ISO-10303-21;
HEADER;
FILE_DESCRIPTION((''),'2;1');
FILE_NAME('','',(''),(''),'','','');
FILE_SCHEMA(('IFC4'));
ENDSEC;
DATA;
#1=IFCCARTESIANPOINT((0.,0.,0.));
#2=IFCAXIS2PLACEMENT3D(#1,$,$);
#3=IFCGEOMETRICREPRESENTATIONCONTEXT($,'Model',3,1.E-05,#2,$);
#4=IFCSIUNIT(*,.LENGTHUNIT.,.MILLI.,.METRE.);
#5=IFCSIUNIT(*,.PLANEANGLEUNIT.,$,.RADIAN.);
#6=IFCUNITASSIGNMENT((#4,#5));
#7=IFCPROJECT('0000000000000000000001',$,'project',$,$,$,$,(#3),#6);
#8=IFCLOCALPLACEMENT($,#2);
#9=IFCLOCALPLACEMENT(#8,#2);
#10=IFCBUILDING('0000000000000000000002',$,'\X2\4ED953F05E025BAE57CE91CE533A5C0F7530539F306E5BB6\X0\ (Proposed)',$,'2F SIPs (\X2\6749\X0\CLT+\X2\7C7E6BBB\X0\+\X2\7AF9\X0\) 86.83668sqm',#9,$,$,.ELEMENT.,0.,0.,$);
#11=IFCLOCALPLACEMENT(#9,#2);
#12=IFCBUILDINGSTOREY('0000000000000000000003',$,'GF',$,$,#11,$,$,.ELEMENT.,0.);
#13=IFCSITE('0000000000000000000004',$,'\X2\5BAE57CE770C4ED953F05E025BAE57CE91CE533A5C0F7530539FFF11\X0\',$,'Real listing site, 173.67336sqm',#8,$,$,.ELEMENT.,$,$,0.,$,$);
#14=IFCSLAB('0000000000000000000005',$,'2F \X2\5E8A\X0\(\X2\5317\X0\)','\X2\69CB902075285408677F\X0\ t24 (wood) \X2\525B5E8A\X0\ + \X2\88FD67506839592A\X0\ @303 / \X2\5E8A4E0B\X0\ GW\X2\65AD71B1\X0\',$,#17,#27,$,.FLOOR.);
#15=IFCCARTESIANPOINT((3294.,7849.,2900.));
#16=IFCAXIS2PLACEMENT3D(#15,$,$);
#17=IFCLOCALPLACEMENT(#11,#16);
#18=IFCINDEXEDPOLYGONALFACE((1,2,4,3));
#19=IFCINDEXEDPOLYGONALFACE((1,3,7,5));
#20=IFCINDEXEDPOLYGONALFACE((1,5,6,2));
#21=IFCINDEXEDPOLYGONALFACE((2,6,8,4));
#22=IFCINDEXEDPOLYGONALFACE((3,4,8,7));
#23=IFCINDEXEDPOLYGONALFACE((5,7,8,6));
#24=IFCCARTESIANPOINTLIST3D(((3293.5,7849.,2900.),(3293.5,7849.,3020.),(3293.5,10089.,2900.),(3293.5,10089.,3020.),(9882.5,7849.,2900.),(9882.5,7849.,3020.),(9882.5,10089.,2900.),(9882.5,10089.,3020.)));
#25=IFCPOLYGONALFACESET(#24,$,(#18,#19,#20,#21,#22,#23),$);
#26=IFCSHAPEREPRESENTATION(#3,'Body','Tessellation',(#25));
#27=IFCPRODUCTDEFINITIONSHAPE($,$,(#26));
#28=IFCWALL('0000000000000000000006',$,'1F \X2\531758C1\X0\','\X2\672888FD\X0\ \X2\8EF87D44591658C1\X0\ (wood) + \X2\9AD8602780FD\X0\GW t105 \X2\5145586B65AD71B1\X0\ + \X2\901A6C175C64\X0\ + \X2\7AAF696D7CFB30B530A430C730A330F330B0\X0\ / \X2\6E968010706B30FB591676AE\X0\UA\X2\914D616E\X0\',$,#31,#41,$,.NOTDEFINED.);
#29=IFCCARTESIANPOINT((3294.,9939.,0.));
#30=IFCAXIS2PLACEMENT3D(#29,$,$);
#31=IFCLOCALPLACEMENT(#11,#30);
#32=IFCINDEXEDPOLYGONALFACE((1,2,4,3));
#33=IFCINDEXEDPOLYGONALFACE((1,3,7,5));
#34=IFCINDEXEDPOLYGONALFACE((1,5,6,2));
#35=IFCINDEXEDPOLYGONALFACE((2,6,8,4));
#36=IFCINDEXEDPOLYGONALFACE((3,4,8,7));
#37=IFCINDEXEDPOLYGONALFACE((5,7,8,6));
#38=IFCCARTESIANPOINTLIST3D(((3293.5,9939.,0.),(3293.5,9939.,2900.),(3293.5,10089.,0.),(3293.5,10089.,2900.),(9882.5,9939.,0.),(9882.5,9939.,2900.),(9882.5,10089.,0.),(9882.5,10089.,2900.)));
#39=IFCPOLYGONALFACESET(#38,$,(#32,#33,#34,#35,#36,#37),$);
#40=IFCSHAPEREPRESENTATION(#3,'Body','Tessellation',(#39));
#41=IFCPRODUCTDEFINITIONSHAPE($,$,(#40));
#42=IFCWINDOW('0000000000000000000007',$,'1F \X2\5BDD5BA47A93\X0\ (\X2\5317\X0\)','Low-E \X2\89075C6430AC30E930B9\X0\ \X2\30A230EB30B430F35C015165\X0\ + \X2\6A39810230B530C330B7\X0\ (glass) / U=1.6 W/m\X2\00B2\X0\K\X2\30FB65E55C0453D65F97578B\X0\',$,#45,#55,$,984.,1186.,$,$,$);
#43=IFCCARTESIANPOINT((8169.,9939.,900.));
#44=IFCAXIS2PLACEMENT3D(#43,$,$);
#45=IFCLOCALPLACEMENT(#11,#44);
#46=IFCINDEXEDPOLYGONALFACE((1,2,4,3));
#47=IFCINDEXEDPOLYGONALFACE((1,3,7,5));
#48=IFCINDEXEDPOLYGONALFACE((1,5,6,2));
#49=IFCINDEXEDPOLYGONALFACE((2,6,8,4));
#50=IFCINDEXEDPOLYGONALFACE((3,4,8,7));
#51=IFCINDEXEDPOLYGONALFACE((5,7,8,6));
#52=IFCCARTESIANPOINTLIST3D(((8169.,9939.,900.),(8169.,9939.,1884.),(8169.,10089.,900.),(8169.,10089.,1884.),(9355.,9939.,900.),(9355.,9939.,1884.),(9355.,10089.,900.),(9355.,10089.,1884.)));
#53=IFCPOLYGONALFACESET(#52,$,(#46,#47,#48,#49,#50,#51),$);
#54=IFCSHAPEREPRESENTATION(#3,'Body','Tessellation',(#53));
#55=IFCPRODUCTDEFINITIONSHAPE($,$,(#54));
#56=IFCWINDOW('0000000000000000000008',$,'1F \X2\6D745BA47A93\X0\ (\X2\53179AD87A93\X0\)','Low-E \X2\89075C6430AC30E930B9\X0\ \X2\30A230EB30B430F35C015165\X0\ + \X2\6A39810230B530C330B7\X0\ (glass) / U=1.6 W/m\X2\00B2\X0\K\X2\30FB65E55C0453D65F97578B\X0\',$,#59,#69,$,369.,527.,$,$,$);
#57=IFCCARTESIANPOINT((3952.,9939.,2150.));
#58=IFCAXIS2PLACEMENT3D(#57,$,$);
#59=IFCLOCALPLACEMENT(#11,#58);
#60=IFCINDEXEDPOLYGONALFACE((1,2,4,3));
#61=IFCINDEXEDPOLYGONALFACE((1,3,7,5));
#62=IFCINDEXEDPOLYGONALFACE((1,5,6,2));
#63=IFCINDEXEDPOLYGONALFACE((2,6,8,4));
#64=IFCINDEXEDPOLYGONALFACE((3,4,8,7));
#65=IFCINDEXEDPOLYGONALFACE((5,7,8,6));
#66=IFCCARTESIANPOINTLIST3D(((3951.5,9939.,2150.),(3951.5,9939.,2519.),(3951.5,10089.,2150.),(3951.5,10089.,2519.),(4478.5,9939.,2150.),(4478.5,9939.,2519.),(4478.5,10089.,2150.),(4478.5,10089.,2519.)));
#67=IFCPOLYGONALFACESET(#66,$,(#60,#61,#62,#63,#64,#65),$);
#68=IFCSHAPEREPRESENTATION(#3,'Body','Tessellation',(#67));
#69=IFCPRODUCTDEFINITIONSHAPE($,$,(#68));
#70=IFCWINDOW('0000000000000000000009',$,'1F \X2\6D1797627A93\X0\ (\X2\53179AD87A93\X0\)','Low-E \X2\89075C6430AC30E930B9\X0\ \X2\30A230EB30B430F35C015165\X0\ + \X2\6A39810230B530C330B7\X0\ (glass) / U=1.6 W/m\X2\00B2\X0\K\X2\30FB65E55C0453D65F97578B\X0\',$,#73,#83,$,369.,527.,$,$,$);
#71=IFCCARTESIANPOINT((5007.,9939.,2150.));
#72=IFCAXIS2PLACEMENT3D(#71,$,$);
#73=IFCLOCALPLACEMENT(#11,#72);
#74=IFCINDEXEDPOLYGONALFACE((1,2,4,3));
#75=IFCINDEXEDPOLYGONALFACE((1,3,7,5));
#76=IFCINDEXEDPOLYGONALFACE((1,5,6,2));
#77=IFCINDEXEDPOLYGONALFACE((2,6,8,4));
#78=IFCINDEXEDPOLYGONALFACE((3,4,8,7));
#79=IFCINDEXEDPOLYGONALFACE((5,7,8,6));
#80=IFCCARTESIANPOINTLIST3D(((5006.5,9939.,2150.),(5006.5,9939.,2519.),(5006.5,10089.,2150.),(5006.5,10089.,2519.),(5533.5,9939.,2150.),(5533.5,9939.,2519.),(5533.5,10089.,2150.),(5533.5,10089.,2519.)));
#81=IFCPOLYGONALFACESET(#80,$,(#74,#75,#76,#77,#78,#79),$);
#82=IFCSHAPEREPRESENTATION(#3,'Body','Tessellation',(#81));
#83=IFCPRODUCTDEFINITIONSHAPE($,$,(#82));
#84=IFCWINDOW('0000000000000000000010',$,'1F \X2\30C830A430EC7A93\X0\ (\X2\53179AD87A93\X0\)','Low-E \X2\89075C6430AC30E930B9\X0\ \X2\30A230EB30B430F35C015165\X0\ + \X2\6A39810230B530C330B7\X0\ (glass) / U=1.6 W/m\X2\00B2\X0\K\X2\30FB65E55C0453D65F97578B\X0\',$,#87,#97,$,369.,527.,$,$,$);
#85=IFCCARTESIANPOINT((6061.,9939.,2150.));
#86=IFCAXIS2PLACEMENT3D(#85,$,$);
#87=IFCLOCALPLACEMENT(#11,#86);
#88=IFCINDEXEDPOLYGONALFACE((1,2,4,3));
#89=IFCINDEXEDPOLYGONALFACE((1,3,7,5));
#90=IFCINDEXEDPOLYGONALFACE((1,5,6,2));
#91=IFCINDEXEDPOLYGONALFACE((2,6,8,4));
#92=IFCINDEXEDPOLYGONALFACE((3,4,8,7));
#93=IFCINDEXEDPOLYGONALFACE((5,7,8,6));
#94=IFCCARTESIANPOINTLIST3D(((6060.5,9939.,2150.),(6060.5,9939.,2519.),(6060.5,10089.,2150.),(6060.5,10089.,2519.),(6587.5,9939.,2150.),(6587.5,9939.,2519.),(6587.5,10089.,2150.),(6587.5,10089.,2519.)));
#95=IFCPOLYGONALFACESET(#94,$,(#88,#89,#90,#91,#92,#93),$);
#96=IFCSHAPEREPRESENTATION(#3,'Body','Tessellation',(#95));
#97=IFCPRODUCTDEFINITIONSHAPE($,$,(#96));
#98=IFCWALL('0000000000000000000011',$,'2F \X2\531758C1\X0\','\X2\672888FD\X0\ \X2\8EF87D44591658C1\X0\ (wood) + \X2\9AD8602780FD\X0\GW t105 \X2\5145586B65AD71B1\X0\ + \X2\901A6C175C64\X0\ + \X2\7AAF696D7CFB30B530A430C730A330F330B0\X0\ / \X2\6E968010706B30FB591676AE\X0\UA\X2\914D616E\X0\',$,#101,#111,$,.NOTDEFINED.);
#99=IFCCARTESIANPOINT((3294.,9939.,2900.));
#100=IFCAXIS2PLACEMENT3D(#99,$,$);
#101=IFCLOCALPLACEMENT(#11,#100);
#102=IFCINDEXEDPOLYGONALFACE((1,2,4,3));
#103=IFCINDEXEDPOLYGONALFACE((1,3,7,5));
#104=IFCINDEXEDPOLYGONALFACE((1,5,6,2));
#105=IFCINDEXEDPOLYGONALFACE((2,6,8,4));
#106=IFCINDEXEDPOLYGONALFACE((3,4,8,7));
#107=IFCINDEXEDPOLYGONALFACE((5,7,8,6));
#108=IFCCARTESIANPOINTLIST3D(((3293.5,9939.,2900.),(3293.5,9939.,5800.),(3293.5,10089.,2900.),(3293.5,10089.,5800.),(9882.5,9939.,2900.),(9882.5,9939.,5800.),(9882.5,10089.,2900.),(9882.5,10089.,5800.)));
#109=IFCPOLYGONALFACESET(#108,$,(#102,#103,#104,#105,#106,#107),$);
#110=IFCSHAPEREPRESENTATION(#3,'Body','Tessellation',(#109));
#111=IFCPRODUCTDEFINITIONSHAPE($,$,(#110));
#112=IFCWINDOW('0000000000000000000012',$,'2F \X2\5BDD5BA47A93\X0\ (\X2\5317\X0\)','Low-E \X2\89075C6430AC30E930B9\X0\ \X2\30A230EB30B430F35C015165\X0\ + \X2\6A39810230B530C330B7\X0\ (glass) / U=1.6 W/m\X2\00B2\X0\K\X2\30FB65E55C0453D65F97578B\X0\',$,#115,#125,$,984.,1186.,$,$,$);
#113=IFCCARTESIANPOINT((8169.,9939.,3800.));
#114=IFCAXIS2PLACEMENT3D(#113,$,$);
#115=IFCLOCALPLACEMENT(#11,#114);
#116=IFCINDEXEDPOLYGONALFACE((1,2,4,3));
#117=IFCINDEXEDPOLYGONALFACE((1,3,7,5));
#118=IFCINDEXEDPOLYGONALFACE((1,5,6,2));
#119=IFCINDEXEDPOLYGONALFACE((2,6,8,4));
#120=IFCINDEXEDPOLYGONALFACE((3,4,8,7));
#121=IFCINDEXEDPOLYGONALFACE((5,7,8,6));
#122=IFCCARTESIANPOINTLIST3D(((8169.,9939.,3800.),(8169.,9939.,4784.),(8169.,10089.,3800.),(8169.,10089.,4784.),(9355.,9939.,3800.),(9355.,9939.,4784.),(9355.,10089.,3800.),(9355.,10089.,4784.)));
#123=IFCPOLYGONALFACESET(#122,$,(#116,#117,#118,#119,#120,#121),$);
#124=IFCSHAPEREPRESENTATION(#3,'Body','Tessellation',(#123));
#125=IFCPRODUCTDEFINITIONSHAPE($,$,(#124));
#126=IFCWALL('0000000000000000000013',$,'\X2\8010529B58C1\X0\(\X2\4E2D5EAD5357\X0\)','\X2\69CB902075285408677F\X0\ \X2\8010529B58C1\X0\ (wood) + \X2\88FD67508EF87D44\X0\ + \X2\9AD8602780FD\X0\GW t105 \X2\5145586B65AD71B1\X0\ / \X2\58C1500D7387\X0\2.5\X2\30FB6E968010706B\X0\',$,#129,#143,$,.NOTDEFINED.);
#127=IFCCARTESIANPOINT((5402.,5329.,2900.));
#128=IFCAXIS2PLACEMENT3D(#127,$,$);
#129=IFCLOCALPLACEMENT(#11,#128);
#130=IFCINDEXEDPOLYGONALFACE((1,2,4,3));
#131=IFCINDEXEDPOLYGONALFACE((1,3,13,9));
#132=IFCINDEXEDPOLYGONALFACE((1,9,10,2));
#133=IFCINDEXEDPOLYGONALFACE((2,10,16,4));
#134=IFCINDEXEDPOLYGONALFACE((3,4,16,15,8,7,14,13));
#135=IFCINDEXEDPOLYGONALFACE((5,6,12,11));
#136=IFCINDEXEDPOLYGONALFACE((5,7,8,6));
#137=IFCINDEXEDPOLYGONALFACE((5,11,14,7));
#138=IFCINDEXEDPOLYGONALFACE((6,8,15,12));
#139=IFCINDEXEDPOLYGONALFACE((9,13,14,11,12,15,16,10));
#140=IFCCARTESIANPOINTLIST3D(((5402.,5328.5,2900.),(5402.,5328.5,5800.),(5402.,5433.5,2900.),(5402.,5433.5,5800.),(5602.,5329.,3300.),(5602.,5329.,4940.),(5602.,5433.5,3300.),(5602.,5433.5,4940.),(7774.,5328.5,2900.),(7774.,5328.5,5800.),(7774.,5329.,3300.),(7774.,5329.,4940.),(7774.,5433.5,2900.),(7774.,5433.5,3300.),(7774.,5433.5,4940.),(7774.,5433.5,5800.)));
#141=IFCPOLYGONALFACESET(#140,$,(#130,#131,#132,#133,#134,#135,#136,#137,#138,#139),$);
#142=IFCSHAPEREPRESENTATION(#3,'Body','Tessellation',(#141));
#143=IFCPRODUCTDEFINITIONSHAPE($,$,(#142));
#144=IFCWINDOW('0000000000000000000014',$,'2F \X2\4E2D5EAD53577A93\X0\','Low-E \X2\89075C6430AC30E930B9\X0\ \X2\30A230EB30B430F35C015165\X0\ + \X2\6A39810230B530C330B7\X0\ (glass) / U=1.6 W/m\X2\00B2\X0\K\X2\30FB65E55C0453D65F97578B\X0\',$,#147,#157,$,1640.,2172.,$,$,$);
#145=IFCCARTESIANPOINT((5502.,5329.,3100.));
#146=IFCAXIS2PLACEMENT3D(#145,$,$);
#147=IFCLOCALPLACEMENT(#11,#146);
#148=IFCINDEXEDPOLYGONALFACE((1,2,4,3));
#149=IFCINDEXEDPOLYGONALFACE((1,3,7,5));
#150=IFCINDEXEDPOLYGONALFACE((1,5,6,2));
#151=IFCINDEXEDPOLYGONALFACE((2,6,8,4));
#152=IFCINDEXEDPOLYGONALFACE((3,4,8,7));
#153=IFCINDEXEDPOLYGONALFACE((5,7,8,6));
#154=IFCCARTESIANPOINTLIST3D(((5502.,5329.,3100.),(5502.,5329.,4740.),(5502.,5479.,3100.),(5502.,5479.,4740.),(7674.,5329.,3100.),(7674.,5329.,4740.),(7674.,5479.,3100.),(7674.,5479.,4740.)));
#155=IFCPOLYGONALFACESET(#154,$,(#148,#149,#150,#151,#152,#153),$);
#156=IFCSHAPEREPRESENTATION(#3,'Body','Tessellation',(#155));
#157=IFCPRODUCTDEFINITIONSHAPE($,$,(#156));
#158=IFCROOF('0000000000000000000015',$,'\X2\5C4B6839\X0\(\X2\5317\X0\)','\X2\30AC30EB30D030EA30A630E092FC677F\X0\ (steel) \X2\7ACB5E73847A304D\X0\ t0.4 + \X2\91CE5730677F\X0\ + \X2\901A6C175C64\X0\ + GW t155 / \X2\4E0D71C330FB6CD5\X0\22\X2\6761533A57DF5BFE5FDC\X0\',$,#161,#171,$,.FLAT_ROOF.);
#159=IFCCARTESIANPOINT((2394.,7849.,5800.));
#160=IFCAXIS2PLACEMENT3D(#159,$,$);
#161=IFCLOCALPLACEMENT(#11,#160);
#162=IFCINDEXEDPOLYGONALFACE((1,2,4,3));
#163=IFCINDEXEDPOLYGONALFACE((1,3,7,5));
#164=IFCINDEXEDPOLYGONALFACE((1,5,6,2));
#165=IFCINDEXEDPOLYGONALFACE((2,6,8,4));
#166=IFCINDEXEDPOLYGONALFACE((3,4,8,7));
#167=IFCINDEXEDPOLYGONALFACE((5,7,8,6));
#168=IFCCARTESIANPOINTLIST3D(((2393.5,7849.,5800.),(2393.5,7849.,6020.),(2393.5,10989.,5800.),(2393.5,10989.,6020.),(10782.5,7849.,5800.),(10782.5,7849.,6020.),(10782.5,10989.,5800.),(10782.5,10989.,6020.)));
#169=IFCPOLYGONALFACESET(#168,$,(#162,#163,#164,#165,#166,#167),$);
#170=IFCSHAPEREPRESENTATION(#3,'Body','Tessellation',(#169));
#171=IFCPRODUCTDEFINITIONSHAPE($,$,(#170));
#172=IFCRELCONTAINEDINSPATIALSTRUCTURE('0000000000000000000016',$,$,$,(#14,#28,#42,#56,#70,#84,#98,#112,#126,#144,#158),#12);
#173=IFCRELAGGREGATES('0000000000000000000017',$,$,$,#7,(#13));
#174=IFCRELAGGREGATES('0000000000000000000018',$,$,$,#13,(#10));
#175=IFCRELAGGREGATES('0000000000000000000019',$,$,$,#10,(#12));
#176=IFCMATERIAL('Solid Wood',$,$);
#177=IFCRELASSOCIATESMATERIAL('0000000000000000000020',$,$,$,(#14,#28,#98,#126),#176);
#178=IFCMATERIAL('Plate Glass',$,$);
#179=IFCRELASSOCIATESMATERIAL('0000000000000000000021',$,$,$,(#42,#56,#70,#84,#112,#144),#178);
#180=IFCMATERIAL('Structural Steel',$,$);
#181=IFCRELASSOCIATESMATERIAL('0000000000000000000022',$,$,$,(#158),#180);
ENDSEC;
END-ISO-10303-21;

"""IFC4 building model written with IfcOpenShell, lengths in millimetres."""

from ifc_helpers import new_model, si_unit, frame, frame_2d, origin, place, context, project, spatial, rectangle, extrude, material, element, fill, save


model = new_model("IFC4")

# Units and contexts
model_context = context("Model", 3, precision=1e-05, world=origin())
ifc_project = project(units=[si_unit("LENGTHUNIT", "METRE", prefix="MILLI"), si_unit("PLANEANGLEUNIT", "RADIAN")], contexts=[model_context])

# Site, building, storey
site_placement = place(None, origin())
site = spatial("IfcSite", under=ifc_project, at=site_placement, Name="宮城県仙台市宮城野区小田原１", ObjectType="Real listing site, 173.67336sqm", CompositionType="ELEMENT", RefElevation=0.0)
building_placement = place(site_placement, origin())
building = spatial("IfcBuilding", under=site, at=building_placement, Name="仙台市宮城野区小田原の家 (Proposed)", ObjectType="2F SIPs (杉CLT+籾殻+竹) 86.83668sqm", CompositionType="ELEMENT", ElevationOfRefHeight=0.0, ElevationOfTerrain=0.0)
storey_placement = place(building_placement, origin())
storey = spatial("IfcBuildingStorey", under=building, at=storey_placement, Name="GF", CompositionType="ELEMENT", Elevation=0.0)

# Slab
ifc_material_1 = material(Name="Solid Wood")
slab_1_placement = place(storey_placement, frame((3294.0, 7849.0, 2900.0)))
element("IfcSlab", 1, at=slab_1_placement, inside=storey, material=ifc_material_1, Name="2F 床(北)", Description="構造用合板 t24 (wood) 剛床 + 製材根太 @303 / 床下 GW断熱", PredefinedType="FLOOR", context=model_context, shape_type="SweptSolid", body=[
    extrude(rectangle(XDim=6589.0, YDim=2240.0, at=frame_2d((3294.0, 1120.0))), frame((3294.0, 7849.0, 2900.0)), (0.0, 0.0, 1.0), 120.0),
])

# Wall, openings, windows
wall_1_placement = place(storey_placement, frame((3294.0, 9939.0, 0.0)))
wall_1 = element("IfcWall", 2, at=wall_1_placement, inside=storey, material=ifc_material_1, Name="1F 北壁", Description="木製 軸組外壁 (wood) + 高性能GW t105 充填断熱 + 通気層 + 窯業系サイディング / 準耐火・外皮UA配慮", PredefinedType="NOTDEFINED", context=model_context, shape_type="SweptSolid", body=[
    extrude(rectangle(XDim=6589.0, YDim=150.0, at=frame_2d((3294.0, 75.0))), frame((3294.0, 9939.0, 0.0)), (0.0, 0.0, 1.0), 2900.0),
])
opening_1_placement = place(storey_placement, frame((8169.0, 9939.0, 900.0)))
opening_1 = element("IfcOpeningElement", 3, at=opening_1_placement, cuts=wall_1, PredefinedType="NOTDEFINED", context=model_context, shape_type="SweptSolid", body=[
    extrude(rectangle(XDim=1186.0, YDim=150.0, at=frame_2d((593.0, 75.0))), frame((8169.0, 9939.0, 900.0)), (0.0, 0.0, 1.0), 984.0),
])
opening_2_placement = place(storey_placement, frame((3952.0, 9939.0, 2150.0)))
opening_2 = element("IfcOpeningElement", 4, at=opening_2_placement, cuts=wall_1, PredefinedType="NOTDEFINED", context=model_context, shape_type="SweptSolid", body=[
    extrude(rectangle(XDim=527.0, YDim=150.0, at=frame_2d((263.0, 75.0))), frame((3952.0, 9939.0, 2150.0)), (0.0, 0.0, 1.0), 369.0),
])
opening_3_placement = place(storey_placement, frame((5007.0, 9939.0, 2150.0)))
opening_3 = element("IfcOpeningElement", 5, at=opening_3_placement, cuts=wall_1, PredefinedType="NOTDEFINED", context=model_context, shape_type="SweptSolid", body=[
    extrude(rectangle(XDim=527.0, YDim=150.0, at=frame_2d((263.0, 75.0))), frame((5007.0, 9939.0, 2150.0)), (0.0, 0.0, 1.0), 369.0),
])
opening_4_placement = place(storey_placement, frame((6061.0, 9939.0, 2150.0)))
opening_4 = element("IfcOpeningElement", 6, at=opening_4_placement, cuts=wall_1, PredefinedType="NOTDEFINED", context=model_context, shape_type="SweptSolid", body=[
    extrude(rectangle(XDim=527.0, YDim=150.0, at=frame_2d((263.0, 75.0))), frame((6061.0, 9939.0, 2150.0)), (0.0, 0.0, 1.0), 369.0),
])
ifc_material_2 = material(Name="Plate Glass")
window_1_placement = place(storey_placement, frame((8169.0, 9939.0, 900.0)))
window_1 = element("IfcWindow", 7, at=window_1_placement, inside=storey, material=ifc_material_2, Name="1F 寝室窓 (北)", Description="Low-E 複層ガラス アルゴン封入 + 樹脂サッシ (glass) / U=1.6 W/m²K・日射取得型", OverallHeight=984.0, OverallWidth=1186.0, context=model_context, shape_type="SweptSolid", body=[
    extrude(rectangle(XDim=1186.0, YDim=150.0, at=frame_2d((593.0, 75.0))), frame((8169.0, 9939.0, 900.0)), (0.0, 0.0, 1.0), 984.0),
])
fill(opening_1, window_1)
window_2_placement = place(storey_placement, frame((3952.0, 9939.0, 2150.0)))
window_2 = element("IfcWindow", 8, at=window_2_placement, inside=storey, material=ifc_material_2, Name="1F 浴室窓 (北高窓)", Description="Low-E 複層ガラス アルゴン封入 + 樹脂サッシ (glass) / U=1.6 W/m²K・日射取得型", OverallHeight=369.0, OverallWidth=527.0, context=model_context, shape_type="SweptSolid", body=[
    extrude(rectangle(XDim=527.0, YDim=150.0, at=frame_2d((263.0, 75.0))), frame((3952.0, 9939.0, 2150.0)), (0.0, 0.0, 1.0), 369.0),
])
fill(opening_2, window_2)
window_3_placement = place(storey_placement, frame((5007.0, 9939.0, 2150.0)))
window_3 = element("IfcWindow", 9, at=window_3_placement, inside=storey, material=ifc_material_2, Name="1F 洗面窓 (北高窓)", Description="Low-E 複層ガラス アルゴン封入 + 樹脂サッシ (glass) / U=1.6 W/m²K・日射取得型", OverallHeight=369.0, OverallWidth=527.0, context=model_context, shape_type="SweptSolid", body=[
    extrude(rectangle(XDim=527.0, YDim=150.0, at=frame_2d((263.0, 75.0))), frame((5007.0, 9939.0, 2150.0)), (0.0, 0.0, 1.0), 369.0),
])
fill(opening_3, window_3)
window_4_placement = place(storey_placement, frame((6061.0, 9939.0, 2150.0)))
window_4 = element("IfcWindow", 10, at=window_4_placement, inside=storey, material=ifc_material_2, Name="1F トイレ窓 (北高窓)", Description="Low-E 複層ガラス アルゴン封入 + 樹脂サッシ (glass) / U=1.6 W/m²K・日射取得型", OverallHeight=369.0, OverallWidth=527.0, context=model_context, shape_type="SweptSolid", body=[
    extrude(rectangle(XDim=527.0, YDim=150.0, at=frame_2d((263.0, 75.0))), frame((6061.0, 9939.0, 2150.0)), (0.0, 0.0, 1.0), 369.0),
])
fill(opening_4, window_4)

# Walls, openings, windows
wall_2_placement = place(storey_placement, frame((3294.0, 9939.0, 2900.0)))
wall_2 = element("IfcWall", 11, at=wall_2_placement, inside=storey, material=ifc_material_1, Name="2F 北壁", Description="木製 軸組外壁 (wood) + 高性能GW t105 充填断熱 + 通気層 + 窯業系サイディング / 準耐火・外皮UA配慮", PredefinedType="NOTDEFINED", context=model_context, shape_type="SweptSolid", body=[
    extrude(rectangle(XDim=6589.0, YDim=150.0, at=frame_2d((3294.0, 75.0))), frame((3294.0, 9939.0, 2900.0)), (0.0, 0.0, 1.0), 2900.0),
])
opening_5_placement = place(storey_placement, frame((8169.0, 9939.0, 3800.0)))
opening_5 = element("IfcOpeningElement", 12, at=opening_5_placement, cuts=wall_2, PredefinedType="NOTDEFINED", context=model_context, shape_type="SweptSolid", body=[
    extrude(rectangle(XDim=1186.0, YDim=150.0, at=frame_2d((593.0, 75.0))), frame((8169.0, 9939.0, 3800.0)), (0.0, 0.0, 1.0), 984.0),
])
window_5_placement = place(storey_placement, frame((8169.0, 9939.0, 3800.0)))
window_5 = element("IfcWindow", 13, at=window_5_placement, inside=storey, material=ifc_material_2, Name="2F 寝室窓 (北)", Description="Low-E 複層ガラス アルゴン封入 + 樹脂サッシ (glass) / U=1.6 W/m²K・日射取得型", OverallHeight=984.0, OverallWidth=1186.0, context=model_context, shape_type="SweptSolid", body=[
    extrude(rectangle(XDim=1186.0, YDim=150.0, at=frame_2d((593.0, 75.0))), frame((8169.0, 9939.0, 3800.0)), (0.0, 0.0, 1.0), 984.0),
])
fill(opening_5, window_5)
wall_3_placement = place(storey_placement, frame((5402.0, 5329.0, 2900.0)))
wall_3 = element("IfcWall", 14, at=wall_3_placement, inside=storey, material=ifc_material_1, Name="耐力壁(中庭南)", Description="構造用合板 耐力壁 (wood) + 製材軸組 + 高性能GW t105 充填断熱 / 壁倍率2.5・準耐火", PredefinedType="NOTDEFINED", context=model_context, shape_type="SweptSolid", body=[
    extrude(rectangle(XDim=2372.0, YDim=105.0, at=frame_2d((1186.0, 52.0))), frame((5402.0, 5329.0, 2900.0)), (0.0, 0.0, 1.0), 2900.0),
])
opening_6_placement = place(storey_placement, frame((5502.0, 5329.0, 3100.0)))
opening_6 = element("IfcOpeningElement", 15, at=opening_6_placement, cuts=wall_3, PredefinedType="NOTDEFINED", context=model_context, shape_type="SweptSolid", body=[
    extrude(rectangle(XDim=2172.0, YDim=150.0, at=frame_2d((1086.0, 75.0))), frame((5502.0, 5329.0, 3100.0)), (0.0, 0.0, 1.0), 1640.0),
])
window_6_placement = place(storey_placement, frame((5502.0, 5329.0, 3100.0)))
window_6 = element("IfcWindow", 16, at=window_6_placement, inside=storey, material=ifc_material_2, Name="2F 中庭南窓", Description="Low-E 複層ガラス アルゴン封入 + 樹脂サッシ (glass) / U=1.6 W/m²K・日射取得型", OverallHeight=1640.0, OverallWidth=2172.0, context=model_context, shape_type="SweptSolid", body=[
    extrude(rectangle(XDim=2172.0, YDim=150.0, at=frame_2d((1086.0, 75.0))), frame((5502.0, 5329.0, 3100.0)), (0.0, 0.0, 1.0), 1640.0),
])
fill(opening_6, window_6)

# Roof
ifc_material_3 = material(Name="Structural Steel")
for number, where, name in (
    (17, (2394.0, 7849.0, 5800.0), "屋根(北)"),
):
    element("IfcRoof", number, at=place(storey_placement, frame(where)), inside=storey, material=ifc_material_3, Name=name, Description="ガルバリウム鋼板 (steel) 立平葺き t0.4 + 野地板 + 通気層 + GW t155 / 不燃・法22条区域対応", PredefinedType="FLAT_ROOF", context=model_context, shape_type="SweptSolid", body=[
        extrude(rectangle(XDim=8389.0, YDim=3140.0, at=frame_2d((4194.0, 1570.0))), frame((2394.0, 7849.0, 5800.0)), (0.0, 0.0, 1.0), 220.0),
    ])

save(model, "model.ifc")
